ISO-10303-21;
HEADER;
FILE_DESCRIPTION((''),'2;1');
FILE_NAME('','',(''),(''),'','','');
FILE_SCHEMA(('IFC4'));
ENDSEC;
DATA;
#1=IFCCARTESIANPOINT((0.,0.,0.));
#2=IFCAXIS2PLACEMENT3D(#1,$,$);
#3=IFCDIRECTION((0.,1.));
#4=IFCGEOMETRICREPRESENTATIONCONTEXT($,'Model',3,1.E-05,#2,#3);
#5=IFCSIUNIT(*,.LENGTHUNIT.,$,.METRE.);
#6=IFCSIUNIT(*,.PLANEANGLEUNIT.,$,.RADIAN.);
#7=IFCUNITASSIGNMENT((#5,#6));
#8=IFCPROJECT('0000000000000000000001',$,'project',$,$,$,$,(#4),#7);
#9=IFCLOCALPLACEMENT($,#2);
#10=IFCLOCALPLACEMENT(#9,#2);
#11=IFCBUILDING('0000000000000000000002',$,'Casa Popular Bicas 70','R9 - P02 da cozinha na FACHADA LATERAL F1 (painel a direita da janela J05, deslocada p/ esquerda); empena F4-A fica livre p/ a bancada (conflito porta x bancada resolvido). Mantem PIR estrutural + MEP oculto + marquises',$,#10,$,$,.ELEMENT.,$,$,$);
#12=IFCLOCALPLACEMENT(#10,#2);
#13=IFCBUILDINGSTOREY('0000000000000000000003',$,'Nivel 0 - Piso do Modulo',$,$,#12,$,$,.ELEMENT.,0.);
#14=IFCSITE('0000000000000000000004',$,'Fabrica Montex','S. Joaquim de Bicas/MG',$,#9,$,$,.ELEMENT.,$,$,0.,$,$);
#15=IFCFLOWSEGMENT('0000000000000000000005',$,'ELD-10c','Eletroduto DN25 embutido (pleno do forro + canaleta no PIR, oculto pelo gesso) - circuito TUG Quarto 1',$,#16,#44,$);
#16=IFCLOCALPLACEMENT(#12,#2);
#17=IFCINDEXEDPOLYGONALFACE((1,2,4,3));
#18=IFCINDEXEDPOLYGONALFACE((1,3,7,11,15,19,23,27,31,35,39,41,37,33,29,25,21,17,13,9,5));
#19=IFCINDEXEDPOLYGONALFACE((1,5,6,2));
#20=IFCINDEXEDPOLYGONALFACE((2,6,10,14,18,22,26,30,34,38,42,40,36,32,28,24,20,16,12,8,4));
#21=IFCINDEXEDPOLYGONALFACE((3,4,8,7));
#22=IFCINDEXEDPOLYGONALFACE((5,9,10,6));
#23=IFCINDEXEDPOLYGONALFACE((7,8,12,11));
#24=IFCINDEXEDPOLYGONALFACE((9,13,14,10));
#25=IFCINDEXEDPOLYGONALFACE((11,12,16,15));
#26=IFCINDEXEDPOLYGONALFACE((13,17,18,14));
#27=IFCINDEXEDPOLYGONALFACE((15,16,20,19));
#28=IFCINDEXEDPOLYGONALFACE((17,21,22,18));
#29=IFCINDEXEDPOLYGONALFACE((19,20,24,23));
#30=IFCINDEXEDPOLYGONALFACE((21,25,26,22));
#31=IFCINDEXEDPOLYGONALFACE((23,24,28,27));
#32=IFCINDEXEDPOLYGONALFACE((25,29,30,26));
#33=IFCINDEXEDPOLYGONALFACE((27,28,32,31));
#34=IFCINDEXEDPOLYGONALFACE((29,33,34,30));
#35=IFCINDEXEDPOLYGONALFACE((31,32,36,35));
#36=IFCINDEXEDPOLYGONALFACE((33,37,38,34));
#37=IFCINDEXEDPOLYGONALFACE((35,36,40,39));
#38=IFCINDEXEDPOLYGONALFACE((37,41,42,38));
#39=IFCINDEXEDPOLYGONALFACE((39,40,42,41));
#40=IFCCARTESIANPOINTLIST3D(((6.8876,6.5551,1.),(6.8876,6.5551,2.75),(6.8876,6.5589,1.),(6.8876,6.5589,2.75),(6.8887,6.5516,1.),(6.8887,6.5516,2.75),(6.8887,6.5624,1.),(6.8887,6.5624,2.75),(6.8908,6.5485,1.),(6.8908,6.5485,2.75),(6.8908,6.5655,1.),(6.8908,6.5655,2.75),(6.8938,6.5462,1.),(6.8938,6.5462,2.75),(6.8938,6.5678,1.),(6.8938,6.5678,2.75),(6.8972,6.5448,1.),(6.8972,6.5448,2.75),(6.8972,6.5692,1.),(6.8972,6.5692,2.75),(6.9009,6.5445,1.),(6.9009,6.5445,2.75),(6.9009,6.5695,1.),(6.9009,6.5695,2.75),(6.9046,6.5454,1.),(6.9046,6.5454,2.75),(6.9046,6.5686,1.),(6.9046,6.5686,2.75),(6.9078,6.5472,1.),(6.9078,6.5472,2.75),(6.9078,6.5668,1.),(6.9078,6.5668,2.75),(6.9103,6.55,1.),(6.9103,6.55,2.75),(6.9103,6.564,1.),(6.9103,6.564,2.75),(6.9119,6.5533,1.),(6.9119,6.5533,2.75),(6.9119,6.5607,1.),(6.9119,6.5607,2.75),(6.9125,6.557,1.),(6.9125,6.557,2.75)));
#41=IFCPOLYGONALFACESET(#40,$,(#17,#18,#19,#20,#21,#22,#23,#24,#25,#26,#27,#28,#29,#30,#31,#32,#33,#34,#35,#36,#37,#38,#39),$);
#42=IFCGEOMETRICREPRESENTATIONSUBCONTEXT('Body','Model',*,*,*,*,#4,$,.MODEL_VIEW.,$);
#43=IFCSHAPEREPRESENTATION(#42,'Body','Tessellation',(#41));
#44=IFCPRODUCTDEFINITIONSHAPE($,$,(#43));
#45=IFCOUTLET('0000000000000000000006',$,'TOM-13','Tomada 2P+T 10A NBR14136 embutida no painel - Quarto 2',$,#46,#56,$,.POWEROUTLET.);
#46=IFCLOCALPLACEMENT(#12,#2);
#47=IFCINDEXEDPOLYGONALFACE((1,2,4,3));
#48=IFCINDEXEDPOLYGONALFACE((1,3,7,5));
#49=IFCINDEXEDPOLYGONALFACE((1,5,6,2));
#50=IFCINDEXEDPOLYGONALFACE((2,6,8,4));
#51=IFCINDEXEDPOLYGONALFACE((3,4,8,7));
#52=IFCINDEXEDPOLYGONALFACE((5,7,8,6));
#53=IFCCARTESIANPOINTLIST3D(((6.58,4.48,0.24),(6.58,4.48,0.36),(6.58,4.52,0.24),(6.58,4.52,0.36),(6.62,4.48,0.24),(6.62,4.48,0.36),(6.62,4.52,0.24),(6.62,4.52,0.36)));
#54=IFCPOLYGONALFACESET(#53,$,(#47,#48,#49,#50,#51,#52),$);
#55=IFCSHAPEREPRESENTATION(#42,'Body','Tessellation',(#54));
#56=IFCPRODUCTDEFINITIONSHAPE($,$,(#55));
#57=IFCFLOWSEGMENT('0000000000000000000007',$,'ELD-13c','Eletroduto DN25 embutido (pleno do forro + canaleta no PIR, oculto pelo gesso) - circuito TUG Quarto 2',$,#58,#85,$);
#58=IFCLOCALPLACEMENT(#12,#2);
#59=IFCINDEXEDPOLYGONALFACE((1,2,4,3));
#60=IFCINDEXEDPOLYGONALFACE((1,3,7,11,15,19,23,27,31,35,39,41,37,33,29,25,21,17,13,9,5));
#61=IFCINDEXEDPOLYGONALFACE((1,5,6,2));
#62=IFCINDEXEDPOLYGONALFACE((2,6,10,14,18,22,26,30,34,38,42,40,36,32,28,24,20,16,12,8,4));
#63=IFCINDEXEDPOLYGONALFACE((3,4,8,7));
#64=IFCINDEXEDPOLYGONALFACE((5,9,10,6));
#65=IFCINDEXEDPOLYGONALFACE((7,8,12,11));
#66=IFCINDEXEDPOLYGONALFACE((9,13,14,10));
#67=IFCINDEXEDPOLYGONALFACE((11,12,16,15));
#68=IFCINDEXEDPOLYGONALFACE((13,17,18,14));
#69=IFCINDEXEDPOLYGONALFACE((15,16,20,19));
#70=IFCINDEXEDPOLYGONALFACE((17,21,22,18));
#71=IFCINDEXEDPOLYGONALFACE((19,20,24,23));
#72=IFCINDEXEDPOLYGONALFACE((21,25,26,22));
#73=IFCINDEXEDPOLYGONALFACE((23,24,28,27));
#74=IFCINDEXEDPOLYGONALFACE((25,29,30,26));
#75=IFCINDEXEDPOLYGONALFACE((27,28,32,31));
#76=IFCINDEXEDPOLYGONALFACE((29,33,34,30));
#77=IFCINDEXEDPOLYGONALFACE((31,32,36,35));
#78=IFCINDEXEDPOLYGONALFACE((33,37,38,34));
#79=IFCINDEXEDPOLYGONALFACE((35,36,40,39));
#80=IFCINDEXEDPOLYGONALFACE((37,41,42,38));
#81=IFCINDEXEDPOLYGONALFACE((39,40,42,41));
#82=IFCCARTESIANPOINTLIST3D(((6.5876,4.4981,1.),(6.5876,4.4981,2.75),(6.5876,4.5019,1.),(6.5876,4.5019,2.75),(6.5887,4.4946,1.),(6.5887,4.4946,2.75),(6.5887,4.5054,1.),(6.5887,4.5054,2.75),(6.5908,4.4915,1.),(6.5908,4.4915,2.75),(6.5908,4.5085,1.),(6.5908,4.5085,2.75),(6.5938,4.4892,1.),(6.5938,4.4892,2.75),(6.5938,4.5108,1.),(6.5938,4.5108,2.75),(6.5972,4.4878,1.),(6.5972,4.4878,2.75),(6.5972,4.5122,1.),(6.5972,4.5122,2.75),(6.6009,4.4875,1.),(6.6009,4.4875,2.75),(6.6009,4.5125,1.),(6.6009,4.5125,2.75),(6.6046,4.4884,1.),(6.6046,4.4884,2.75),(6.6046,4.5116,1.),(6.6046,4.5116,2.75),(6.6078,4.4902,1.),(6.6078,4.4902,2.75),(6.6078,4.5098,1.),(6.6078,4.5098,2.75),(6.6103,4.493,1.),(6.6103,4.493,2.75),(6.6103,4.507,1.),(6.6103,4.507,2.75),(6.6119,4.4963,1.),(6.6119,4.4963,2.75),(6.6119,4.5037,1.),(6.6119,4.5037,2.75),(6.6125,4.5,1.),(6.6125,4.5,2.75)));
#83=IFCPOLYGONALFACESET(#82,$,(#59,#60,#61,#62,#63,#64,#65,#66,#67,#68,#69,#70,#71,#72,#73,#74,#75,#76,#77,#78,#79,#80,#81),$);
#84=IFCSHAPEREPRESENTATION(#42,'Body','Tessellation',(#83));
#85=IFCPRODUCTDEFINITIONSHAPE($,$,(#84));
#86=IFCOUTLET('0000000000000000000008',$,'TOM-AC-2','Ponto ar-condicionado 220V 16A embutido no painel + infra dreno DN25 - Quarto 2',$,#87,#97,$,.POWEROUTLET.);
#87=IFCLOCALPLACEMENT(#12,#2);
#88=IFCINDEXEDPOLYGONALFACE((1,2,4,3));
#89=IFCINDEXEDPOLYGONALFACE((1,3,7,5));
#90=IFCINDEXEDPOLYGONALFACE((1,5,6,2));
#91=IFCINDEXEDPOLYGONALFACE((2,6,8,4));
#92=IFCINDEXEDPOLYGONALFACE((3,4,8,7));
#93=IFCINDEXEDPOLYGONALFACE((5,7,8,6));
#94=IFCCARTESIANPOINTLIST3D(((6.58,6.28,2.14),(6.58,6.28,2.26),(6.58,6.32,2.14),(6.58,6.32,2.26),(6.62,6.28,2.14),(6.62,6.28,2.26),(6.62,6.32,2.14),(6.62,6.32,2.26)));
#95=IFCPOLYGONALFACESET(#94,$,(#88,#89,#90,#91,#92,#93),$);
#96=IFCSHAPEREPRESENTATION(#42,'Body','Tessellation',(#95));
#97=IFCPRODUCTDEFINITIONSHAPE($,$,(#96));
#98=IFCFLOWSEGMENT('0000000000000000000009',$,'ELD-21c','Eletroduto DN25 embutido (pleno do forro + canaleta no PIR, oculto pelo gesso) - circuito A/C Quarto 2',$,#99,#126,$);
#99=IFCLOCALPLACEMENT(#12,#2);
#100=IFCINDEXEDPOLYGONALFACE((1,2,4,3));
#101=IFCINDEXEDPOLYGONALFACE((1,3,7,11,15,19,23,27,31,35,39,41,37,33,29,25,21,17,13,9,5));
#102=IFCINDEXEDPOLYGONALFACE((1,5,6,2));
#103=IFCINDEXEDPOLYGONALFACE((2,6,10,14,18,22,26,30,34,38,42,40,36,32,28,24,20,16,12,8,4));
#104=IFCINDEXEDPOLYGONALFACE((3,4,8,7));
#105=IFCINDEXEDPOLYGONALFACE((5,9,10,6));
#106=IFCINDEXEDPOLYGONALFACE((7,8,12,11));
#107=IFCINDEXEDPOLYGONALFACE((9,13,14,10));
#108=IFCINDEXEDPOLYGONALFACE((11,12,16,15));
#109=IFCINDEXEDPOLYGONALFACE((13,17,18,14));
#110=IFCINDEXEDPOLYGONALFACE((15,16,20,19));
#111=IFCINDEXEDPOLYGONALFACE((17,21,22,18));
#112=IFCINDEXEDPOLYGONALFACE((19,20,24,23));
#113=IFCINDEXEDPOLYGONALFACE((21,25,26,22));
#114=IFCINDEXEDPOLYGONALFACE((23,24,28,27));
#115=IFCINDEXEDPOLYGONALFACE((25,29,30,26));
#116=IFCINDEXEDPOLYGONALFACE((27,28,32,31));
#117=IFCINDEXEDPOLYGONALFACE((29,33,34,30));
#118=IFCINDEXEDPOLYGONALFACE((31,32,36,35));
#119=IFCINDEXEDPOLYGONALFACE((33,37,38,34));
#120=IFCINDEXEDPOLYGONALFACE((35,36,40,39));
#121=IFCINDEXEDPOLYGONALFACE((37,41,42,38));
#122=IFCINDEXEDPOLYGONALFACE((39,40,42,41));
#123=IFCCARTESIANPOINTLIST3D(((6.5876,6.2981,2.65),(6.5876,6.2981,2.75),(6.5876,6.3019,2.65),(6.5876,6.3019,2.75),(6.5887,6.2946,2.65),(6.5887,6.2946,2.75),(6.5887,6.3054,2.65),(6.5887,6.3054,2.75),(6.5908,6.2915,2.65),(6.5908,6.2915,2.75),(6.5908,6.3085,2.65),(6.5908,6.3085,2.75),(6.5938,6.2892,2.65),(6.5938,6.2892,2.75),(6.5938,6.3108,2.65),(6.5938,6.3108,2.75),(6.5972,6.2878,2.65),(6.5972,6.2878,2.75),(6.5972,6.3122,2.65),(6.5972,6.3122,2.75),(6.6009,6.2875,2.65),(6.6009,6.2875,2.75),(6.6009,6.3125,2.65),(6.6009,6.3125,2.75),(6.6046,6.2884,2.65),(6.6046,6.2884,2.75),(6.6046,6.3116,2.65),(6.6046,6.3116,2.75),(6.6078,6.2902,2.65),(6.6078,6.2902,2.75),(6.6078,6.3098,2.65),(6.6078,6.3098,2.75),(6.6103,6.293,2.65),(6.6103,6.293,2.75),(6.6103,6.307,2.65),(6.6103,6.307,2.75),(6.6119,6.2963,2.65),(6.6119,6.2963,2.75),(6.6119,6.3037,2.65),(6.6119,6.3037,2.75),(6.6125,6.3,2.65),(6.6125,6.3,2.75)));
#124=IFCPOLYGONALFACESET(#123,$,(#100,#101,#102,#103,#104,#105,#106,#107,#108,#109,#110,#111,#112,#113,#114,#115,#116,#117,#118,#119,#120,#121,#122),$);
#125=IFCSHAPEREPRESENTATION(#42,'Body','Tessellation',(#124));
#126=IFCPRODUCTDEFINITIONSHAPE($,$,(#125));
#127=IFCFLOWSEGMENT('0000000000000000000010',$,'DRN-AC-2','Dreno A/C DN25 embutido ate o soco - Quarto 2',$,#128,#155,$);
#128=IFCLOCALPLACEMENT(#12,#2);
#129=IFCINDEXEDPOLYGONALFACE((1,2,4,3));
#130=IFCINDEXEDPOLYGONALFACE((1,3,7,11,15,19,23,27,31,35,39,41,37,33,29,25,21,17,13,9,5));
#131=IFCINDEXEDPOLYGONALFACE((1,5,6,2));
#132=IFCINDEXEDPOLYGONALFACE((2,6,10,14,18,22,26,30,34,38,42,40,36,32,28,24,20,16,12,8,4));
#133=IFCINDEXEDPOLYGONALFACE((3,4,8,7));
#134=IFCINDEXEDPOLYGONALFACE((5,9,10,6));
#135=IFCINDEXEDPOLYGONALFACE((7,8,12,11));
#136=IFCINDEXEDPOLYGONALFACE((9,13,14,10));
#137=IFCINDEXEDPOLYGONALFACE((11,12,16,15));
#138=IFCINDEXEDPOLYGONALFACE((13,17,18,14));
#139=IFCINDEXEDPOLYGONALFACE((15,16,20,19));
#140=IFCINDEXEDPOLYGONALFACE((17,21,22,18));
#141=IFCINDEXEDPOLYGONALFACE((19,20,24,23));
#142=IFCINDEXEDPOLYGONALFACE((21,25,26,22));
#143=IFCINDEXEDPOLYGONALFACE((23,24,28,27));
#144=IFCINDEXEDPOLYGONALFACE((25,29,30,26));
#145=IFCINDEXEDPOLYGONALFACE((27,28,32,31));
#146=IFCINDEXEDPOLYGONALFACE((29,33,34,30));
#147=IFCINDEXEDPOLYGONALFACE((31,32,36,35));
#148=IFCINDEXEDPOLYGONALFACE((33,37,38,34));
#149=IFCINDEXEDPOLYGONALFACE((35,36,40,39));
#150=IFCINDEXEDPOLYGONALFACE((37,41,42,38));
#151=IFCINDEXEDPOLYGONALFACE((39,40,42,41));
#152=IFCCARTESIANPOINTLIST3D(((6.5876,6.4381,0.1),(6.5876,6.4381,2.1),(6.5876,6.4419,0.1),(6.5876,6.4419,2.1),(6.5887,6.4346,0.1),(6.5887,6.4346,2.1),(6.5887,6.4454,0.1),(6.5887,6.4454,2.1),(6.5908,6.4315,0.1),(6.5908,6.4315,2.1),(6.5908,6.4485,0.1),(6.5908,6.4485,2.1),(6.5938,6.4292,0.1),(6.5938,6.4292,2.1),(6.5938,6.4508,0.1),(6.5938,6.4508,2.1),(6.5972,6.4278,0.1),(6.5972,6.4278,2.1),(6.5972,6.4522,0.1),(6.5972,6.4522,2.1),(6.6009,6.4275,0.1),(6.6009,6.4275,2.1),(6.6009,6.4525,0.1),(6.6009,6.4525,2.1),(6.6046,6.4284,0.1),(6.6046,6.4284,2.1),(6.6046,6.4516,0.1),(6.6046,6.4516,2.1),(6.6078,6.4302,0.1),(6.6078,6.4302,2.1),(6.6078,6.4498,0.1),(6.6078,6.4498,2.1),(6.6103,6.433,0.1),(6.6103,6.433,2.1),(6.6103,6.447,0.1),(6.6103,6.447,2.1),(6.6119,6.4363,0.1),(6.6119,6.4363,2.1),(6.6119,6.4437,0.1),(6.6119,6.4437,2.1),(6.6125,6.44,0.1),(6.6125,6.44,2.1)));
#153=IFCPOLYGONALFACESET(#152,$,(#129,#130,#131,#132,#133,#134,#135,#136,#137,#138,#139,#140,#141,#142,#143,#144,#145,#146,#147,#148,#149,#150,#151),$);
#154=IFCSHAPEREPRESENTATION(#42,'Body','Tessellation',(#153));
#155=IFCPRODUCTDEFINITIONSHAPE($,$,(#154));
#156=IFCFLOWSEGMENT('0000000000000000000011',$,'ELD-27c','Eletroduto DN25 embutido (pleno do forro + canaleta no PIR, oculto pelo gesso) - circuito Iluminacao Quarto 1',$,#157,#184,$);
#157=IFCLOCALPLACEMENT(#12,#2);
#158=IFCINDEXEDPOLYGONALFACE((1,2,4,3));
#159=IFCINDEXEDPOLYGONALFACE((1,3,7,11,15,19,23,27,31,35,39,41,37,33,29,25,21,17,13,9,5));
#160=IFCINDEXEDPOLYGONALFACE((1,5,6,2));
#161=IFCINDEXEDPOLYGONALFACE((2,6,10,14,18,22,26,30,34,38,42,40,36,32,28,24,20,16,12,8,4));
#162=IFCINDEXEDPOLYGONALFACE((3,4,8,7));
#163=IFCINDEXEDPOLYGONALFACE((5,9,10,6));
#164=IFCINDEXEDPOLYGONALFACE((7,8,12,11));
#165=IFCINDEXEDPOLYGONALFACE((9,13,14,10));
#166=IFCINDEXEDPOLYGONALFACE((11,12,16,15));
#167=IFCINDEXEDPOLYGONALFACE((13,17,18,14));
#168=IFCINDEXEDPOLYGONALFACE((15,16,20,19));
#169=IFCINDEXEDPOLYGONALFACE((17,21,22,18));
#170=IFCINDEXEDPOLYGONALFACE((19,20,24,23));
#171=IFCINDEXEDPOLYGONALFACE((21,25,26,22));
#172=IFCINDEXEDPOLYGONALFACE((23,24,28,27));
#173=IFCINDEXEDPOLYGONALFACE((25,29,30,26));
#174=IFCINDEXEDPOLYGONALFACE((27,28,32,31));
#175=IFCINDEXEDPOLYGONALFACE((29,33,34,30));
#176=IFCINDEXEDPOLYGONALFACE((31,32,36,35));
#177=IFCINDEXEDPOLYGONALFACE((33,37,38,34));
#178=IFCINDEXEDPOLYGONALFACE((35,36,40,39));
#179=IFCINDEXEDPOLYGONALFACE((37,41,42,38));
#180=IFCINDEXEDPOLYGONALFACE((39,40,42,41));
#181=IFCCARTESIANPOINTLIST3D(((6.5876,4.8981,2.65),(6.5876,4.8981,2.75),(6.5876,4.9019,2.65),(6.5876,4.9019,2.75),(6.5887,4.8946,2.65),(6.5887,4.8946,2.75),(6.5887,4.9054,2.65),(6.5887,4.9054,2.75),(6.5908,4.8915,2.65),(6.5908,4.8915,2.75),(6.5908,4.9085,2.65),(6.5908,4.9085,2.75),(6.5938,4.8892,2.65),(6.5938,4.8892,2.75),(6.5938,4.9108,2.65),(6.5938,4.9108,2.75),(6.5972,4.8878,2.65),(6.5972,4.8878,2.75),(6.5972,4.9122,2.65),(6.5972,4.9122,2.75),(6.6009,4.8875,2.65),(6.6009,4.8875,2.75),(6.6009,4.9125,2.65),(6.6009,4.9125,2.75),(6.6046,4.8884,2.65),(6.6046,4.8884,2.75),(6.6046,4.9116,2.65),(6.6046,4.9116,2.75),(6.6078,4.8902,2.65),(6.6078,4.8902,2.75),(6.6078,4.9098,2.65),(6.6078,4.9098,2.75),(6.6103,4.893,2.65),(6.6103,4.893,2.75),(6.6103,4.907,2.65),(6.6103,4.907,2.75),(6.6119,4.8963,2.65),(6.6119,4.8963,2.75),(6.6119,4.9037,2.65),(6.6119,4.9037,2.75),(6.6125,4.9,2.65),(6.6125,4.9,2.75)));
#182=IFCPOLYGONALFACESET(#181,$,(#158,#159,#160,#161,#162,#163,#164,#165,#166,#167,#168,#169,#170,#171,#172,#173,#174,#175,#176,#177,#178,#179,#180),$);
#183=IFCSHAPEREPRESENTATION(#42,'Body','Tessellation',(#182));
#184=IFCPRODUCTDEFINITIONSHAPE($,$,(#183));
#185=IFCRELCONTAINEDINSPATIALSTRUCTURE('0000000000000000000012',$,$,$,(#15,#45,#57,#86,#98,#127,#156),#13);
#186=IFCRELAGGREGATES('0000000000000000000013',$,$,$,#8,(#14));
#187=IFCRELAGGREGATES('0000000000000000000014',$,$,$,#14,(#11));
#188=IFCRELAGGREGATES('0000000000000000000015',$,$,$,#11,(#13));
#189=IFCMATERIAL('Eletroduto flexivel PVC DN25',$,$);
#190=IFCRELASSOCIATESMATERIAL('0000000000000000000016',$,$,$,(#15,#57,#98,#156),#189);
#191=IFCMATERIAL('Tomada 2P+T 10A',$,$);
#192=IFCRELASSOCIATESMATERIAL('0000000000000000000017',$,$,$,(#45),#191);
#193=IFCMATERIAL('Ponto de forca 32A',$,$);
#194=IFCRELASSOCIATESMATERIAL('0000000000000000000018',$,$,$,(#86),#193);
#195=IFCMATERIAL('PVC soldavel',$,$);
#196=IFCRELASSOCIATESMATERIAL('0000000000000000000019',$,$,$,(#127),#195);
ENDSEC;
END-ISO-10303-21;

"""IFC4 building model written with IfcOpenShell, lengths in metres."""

from ifc_helpers import new_model, si_unit, direction, frame, frame_2d, origin, origin_2d, place, context, subcontext, project, spatial, rectangle, circle, extrude, material, element, save


model = new_model("IFC4")

# Units and contexts
model_context_1 = context("Model", 3, precision=1e-05, world=origin(), true_north=direction((0.0, 1.0)))
body_context_1 = subcontext(model_context_1, "Body", "Model", "MODEL_VIEW")
ifc_project = project(units=[si_unit("LENGTHUNIT", "METRE"), si_unit("PLANEANGLEUNIT", "RADIAN")], contexts=[model_context_1])

# Site, building, storey
site_placement = place(None, origin())
site = spatial("IfcSite", under=ifc_project, at=site_placement, Name="Fabrica Montex", Description="S. Joaquim de Bicas/MG", CompositionType="ELEMENT", RefElevation=0.0)
building_placement = place(site_placement, origin())
building = spatial("IfcBuilding", under=site, at=building_placement, Name="Casa Popular Bicas 70", Description="R9 - P02 da cozinha na FACHADA LATERAL F1 (painel a direita da janela J05, deslocada p/ esquerda); empena F4-A fica livre p/ a bancada (conflito porta x bancada resolvido). Mantem PIR estrutural + MEP oculto + marquises", CompositionType="ELEMENT")
storey_placement = place(building_placement, origin())
storey = spatial("IfcBuildingStorey", under=building, at=storey_placement, Name="Nivel 0 - Piso do Modulo", CompositionType="ELEMENT", Elevation=0.0)

# Shared definitions
ifc_material_1 = material(Name="Tomada 2P+T 10A")

# Flow segment
ifc_material_2 = material(Name="Eletroduto flexivel PVC DN25")
flow_segment_1_placement = place(storey_placement, frame((6.9, 6.557, 2.75), z_axis=(0.0, 0.0, -1.0), x_axis=(1.0, 0.0, 0.0)))
element("IfcFlowSegment", 1, at=flow_segment_1_placement, inside=storey, material=ifc_material_2, Name="ELD-10c", Description="Eletroduto DN25 embutido (pleno do forro + canaleta no PIR, oculto pelo gesso) - circuito TUG Quarto 1", context=body_context_1, shape_type="SweptSolid", body=[
    extrude(circle(Radius=0.0125, at=origin_2d()), origin(), (0.0, 0.0, 1.0), 1.75),
])

# Outlet
outlet_1_placement = place(storey_placement, frame((6.58, 4.48, 0.24)))
element("IfcOutlet", 2, at=outlet_1_placement, inside=storey, material=ifc_material_1, Name="TOM-13", Description="Tomada 2P+T 10A NBR14136 embutida no painel - Quarto 2", PredefinedType="POWEROUTLET", context=body_context_1, shape_type="SweptSolid", body=[
    extrude(rectangle(XDim=0.04, YDim=0.04, at=frame_2d((0.02, 0.02))), origin(), (0.0, 0.0, 1.0), 0.12),
])

# Flow segment
flow_segment_2_placement = place(storey_placement, frame((6.6, 4.5, 2.75), z_axis=(0.0, 0.0, -1.0), x_axis=(1.0, 0.0, 0.0)))
element("IfcFlowSegment", 3, at=flow_segment_2_placement, inside=storey, material=ifc_material_2, Name="ELD-13c", Description="Eletroduto DN25 embutido (pleno do forro + canaleta no PIR, oculto pelo gesso) - circuito TUG Quarto 2", context=body_context_1, shape_type="SweptSolid", body=[
    extrude(circle(Radius=0.0125, at=origin_2d()), origin(), (0.0, 0.0, 1.0), 1.75),
])

# Outlet
ifc_material_3 = material(Name="Ponto de forca 32A")
outlet_2_placement = place(storey_placement, frame((6.58, 6.28, 2.14)))
element("IfcOutlet", 4, at=outlet_2_placement, inside=storey, material=ifc_material_3, Name="TOM-AC-2", Description="Ponto ar-condicionado 220V 16A embutido no painel + infra dreno DN25 - Quarto 2", PredefinedType="POWEROUTLET", context=body_context_1, shape_type="SweptSolid", body=[
    extrude(rectangle(XDim=0.04, YDim=0.04, at=frame_2d((0.02, 0.02))), origin(), (0.0, 0.0, 1.0), 0.12),
])

# Flow segments
flow_segment_3_placement = place(storey_placement, frame((6.6, 6.3, 2.75), z_axis=(0.0, 0.0, -1.0), x_axis=(1.0, 0.0, 0.0)))
element("IfcFlowSegment", 5, at=flow_segment_3_placement, inside=storey, material=ifc_material_2, Name="ELD-21c", Description="Eletroduto DN25 embutido (pleno do forro + canaleta no PIR, oculto pelo gesso) - circuito A/C Quarto 2", context=body_context_1, shape_type="SweptSolid", body=[
    extrude(circle(Radius=0.0125, at=origin_2d()), origin(), (0.0, 0.0, 1.0), 0.1),
])
ifc_material_4 = material(Name="PVC soldavel")
flow_segment_4_placement = place(storey_placement, frame((6.6, 6.44, 2.1), z_axis=(0.0, 0.0, -1.0), x_axis=(1.0, 0.0, 0.0)))
element("IfcFlowSegment", 6, at=flow_segment_4_placement, inside=storey, material=ifc_material_4, Name="DRN-AC-2", Description="Dreno A/C DN25 embutido ate o soco - Quarto 2", context=body_context_1, shape_type="SweptSolid", body=[
    extrude(circle(Radius=0.0125, at=origin_2d()), origin(), (0.0, 0.0, 1.0), 2.0),
])
flow_segment_5_placement = place(storey_placement, frame((6.6, 4.9, 2.75), z_axis=(0.0, 0.0, -1.0), x_axis=(1.0, 0.0, 0.0)))
element("IfcFlowSegment", 7, at=flow_segment_5_placement, inside=storey, material=ifc_material_2, Name="ELD-27c", Description="Eletroduto DN25 embutido (pleno do forro + canaleta no PIR, oculto pelo gesso) - circuito Iluminacao Quarto 1", context=body_context_1, shape_type="SweptSolid", body=[
    extrude(circle(Radius=0.0125, at=origin_2d()), origin(), (0.0, 0.0, 1.0), 0.1),
])

save(model, "model.ifc")
